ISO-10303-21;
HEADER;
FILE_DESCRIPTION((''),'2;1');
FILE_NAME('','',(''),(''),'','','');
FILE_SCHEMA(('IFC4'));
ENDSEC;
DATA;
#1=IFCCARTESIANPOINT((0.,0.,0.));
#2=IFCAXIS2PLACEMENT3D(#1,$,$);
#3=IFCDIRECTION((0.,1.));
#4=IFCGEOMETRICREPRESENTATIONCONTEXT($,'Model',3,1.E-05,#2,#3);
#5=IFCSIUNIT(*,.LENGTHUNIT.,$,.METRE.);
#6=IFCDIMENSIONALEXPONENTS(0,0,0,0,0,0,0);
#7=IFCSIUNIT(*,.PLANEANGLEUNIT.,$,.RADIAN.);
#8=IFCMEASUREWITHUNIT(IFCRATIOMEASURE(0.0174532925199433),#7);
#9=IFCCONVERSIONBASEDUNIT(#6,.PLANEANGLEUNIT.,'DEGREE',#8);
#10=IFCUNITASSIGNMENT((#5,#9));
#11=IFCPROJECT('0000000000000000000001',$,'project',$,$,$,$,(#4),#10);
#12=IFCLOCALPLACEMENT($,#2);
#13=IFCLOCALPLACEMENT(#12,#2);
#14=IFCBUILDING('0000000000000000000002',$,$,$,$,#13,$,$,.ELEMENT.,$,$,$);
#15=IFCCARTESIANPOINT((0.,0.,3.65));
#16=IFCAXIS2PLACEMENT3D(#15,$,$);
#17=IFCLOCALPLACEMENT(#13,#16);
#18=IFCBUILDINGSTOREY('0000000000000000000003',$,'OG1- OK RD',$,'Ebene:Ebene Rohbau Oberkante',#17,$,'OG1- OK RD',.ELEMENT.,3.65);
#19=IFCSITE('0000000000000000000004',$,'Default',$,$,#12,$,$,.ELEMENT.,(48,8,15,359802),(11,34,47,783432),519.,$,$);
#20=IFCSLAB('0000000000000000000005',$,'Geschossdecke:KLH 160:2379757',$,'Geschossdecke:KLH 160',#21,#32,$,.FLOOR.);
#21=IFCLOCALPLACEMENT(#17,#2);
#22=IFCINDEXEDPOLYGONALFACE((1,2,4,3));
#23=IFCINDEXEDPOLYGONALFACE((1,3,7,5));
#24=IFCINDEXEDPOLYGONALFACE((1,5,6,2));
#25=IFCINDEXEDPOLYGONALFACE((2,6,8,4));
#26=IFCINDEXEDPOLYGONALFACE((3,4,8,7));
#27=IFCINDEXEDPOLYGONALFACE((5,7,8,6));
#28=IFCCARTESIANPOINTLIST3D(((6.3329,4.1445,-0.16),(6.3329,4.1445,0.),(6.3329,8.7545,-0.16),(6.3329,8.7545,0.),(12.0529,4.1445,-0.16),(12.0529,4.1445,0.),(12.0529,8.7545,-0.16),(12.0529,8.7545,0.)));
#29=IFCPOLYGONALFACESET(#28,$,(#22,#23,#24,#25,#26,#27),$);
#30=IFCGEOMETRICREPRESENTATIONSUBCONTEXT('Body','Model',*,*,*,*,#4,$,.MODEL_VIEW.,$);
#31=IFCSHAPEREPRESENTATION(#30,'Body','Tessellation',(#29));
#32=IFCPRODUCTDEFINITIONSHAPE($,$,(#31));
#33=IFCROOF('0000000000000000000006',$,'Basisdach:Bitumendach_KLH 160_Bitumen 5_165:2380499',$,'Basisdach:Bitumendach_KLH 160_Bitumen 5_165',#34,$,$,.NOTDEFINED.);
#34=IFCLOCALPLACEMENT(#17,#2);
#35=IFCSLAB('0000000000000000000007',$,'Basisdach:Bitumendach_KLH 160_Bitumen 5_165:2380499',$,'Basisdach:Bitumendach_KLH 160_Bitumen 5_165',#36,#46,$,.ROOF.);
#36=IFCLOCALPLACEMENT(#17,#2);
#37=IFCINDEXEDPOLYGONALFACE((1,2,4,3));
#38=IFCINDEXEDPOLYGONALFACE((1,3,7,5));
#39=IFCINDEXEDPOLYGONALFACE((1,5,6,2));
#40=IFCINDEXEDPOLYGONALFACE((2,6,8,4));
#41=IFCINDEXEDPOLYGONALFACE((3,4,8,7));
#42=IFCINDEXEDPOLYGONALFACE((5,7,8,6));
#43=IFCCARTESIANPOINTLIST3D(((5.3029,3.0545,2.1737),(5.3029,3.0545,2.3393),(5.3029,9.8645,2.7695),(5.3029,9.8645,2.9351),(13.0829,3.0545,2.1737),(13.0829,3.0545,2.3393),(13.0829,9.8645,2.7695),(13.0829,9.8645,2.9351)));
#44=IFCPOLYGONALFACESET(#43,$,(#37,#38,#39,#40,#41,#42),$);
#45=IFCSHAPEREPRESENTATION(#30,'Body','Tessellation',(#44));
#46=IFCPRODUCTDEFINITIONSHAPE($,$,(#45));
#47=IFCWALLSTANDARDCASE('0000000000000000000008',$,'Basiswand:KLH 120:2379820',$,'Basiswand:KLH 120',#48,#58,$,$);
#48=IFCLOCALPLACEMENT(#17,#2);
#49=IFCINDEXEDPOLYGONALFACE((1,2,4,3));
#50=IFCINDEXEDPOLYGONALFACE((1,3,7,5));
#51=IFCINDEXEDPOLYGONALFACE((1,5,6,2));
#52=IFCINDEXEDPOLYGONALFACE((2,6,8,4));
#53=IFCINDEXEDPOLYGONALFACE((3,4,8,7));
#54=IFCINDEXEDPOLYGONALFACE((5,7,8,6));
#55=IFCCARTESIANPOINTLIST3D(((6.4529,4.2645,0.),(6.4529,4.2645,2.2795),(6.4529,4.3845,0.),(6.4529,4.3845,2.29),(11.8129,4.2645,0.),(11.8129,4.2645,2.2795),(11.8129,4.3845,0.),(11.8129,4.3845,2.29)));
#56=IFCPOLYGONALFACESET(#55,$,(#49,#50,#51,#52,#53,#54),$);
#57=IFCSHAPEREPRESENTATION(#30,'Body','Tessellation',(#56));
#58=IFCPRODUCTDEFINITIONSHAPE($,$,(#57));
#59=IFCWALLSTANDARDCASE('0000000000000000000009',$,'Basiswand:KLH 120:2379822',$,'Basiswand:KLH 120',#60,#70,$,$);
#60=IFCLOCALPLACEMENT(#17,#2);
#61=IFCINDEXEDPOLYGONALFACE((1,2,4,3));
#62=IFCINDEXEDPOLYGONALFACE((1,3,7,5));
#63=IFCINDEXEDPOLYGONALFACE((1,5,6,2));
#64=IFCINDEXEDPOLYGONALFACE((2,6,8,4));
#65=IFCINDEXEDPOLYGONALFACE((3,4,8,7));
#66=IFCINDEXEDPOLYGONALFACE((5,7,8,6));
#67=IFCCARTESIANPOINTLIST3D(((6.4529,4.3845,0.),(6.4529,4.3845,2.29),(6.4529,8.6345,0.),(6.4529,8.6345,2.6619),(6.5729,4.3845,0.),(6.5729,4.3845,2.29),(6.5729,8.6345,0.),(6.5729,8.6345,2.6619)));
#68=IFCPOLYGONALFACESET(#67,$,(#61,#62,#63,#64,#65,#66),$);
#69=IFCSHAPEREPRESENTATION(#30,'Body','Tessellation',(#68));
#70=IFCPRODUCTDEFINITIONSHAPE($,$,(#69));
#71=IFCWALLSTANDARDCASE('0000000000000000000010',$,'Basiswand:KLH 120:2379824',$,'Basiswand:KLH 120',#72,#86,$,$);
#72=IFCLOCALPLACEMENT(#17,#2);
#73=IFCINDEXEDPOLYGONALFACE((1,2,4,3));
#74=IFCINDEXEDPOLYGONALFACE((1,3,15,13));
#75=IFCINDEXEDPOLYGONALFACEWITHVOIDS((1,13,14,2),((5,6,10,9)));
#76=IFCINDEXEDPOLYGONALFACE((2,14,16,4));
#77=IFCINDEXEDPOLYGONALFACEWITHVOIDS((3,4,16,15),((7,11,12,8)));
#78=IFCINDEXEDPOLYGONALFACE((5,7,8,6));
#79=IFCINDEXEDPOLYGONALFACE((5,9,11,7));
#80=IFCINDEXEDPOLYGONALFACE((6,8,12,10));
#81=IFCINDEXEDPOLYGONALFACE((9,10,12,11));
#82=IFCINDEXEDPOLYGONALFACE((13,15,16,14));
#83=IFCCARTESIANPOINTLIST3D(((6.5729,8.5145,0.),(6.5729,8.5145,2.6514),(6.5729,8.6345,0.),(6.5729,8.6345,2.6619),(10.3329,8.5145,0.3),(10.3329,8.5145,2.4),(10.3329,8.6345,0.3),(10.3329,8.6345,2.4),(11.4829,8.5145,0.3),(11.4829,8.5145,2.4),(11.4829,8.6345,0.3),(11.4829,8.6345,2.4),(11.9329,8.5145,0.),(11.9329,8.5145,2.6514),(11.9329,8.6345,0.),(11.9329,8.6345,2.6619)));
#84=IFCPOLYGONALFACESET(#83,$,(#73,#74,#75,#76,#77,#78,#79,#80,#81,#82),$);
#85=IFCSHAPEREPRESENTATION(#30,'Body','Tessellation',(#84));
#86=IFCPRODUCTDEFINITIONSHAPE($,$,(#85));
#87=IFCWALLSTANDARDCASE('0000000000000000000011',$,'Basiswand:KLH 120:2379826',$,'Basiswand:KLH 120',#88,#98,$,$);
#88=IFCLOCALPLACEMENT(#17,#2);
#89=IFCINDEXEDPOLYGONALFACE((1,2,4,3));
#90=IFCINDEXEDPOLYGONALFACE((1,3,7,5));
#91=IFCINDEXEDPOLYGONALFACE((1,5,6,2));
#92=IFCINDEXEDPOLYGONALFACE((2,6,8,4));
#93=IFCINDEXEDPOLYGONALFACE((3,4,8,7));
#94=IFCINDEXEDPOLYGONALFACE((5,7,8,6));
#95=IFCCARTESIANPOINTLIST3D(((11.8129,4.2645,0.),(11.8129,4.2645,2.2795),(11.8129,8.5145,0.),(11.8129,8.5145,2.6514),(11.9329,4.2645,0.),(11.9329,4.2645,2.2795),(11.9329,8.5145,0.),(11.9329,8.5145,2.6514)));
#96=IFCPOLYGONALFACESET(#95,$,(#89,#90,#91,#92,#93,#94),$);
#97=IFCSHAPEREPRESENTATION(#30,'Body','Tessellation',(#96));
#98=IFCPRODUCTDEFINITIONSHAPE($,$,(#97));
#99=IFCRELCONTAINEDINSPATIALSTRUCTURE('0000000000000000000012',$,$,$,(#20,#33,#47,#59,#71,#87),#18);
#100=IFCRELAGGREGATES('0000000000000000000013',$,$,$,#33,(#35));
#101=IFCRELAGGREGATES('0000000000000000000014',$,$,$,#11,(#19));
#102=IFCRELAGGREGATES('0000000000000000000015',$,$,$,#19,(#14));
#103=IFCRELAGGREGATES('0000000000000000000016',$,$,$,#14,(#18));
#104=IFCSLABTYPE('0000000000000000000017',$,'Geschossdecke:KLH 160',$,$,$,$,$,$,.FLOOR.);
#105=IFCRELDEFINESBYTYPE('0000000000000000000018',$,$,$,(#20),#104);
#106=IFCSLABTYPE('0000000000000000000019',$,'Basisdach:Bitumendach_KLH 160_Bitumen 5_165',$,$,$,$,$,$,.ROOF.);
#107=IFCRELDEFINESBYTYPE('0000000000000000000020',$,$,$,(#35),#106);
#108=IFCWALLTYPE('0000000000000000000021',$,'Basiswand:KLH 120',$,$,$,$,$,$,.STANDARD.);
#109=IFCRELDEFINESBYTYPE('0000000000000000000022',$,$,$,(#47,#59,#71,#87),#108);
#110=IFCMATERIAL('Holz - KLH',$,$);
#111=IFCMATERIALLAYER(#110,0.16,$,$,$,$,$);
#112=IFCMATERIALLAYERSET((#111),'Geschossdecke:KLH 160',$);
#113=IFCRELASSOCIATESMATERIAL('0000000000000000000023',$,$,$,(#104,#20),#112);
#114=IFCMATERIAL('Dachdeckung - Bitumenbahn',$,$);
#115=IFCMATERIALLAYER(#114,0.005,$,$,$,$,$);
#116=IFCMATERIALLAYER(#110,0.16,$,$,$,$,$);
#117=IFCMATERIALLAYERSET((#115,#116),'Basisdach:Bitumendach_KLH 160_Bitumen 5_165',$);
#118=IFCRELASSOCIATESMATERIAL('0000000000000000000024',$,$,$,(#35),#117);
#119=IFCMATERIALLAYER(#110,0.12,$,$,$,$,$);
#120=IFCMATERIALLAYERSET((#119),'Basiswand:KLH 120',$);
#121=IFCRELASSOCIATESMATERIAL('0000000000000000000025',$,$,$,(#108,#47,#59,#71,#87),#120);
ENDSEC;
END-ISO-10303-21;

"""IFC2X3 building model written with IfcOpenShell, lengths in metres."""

from ifc_helpers import new_model, entity, si_unit, converted_unit, direction, frame, frame_2d, origin, place, context, subcontext, project, spatial, polyline, rectangle, extrude, clip, bounded_halfspace, material, layer, layer_set, layer_usage, type_object, element, aggregate, save


model = new_model("IFC2X3")

# Units and contexts
model_context = context("Model", 3, precision=1e-05, world=origin(), true_north=direction((0.0, 1.0)))
body_context = subcontext(model_context, "Body", "Model", "MODEL_VIEW")
ifc_project = project(units=[si_unit("LENGTHUNIT", "METRE"), converted_unit("PLANEANGLEUNIT", "DEGREE", entity("IfcRatioMeasure", 0.0174532925199433), si_unit("PLANEANGLEUNIT", "RADIAN"), dimensions=[0, 0, 0, 0, 0, 0, 0])], contexts=[model_context])

# Site, building, storey
site_placement = place(None, origin())
site = spatial("IfcSite", under=ifc_project, at=site_placement, Name="Default", CompositionType="ELEMENT", RefLatitude=(48, 8, 15, 359802), RefLongitude=(11, 34, 47, 783432), RefElevation=519.0)
building_placement = place(site_placement, origin())
building = spatial("IfcBuilding", under=site, at=building_placement, CompositionType="ELEMENT")
storey_placement = place(building_placement, frame((0.0, 0.0, 3.65)))
storey = spatial("IfcBuildingStorey", under=building, at=storey_placement, Name="OG1- OK RD", ObjectType="Ebene:Ebene Rohbau Oberkante", LongName="OG1- OK RD", CompositionType="ELEMENT", Elevation=3.65)

# Slab
ifc_material_1 = material(Name="Holz - KLH")
ifc_layer_1 = layer(ifc_material_1, 0.16)
ifc_layer_set_1 = layer_set([ifc_layer_1], Name="Geschossdecke:KLH 160")
ifc_layer_usage_1 = layer_usage(ifc_layer_set_1, "AXIS3", "POSITIVE", 0.0)
slab_type_1 = type_object("IfcSlabType", Name="Geschossdecke:KLH 160", PredefinedType="FLOOR", material=ifc_layer_set_1)
slab_1_placement = place(storey_placement, origin())
element("IfcSlab", 1, at=slab_1_placement, inside=storey, type_object=slab_type_1, material=ifc_layer_usage_1, Name="Geschossdecke:KLH 160:2379757", ObjectType="Geschossdecke:KLH 160", PredefinedType="FLOOR", context=body_context, shape_type="SweptSolid", body=[
    extrude(rectangle(XDim=4.61, YDim=5.72, at=frame_2d((0.0, 0.0), x_axis=(1.0, 0.0))), frame((9.1929, 6.4495, 0.0), z_axis=(0.0, 0.0, -1.0), x_axis=(0.0, 1.0, 0.0)), (0.0, 0.0, 1.0), 0.16),
])

# Roof, slab
roof_placement = place(storey_placement, frame((5.3029, 3.0545, 2.1737)))
roof = element("IfcRoof", 2, at=roof_placement, inside=storey, Name="Basisdach:Bitumendach_KLH 160_Bitumen 5_165:2380499", ObjectType="Basisdach:Bitumendach_KLH 160_Bitumen 5_165", ShapeType="NOTDEFINED")
ifc_material_2 = material(Name="Dachdeckung - Bitumenbahn")
ifc_layer_2 = layer(ifc_material_2, 0.005)
ifc_layer_3 = layer(ifc_material_1, 0.16)
ifc_layer_set_2 = layer_set([ifc_layer_2, ifc_layer_3], Name="Basisdach:Bitumendach_KLH 160_Bitumen 5_165")
slab_type_2 = type_object("IfcSlabType", Name="Basisdach:Bitumendach_KLH 160_Bitumen 5_165", PredefinedType="ROOF")
slab_2_placement = place(roof_placement, origin())
slab_2 = element("IfcSlab", 3, at=slab_2_placement, type_object=slab_type_2, material=ifc_layer_set_2, Name="Basisdach:Bitumendach_KLH 160_Bitumen 5_165:2380499", ObjectType="Basisdach:Bitumendach_KLH 160_Bitumen 5_165", PredefinedType="ROOF", context=body_context, shape_type="SweptSolid", body=[
    extrude(rectangle(XDim=6.836, YDim=7.78, at=frame_2d((0.0, 0.0), x_axis=(0.0, -1.0))), frame((3.89, 3.405, 0.2979), z_axis=(0.0, -0.087156, 0.996195), x_axis=(1.0, 0.0, 0.0)), (0.0, 0.087156, 0.996195), 0.1656),
])
aggregate(roof, [slab_2])

# Walls
ifc_layer_4 = layer(ifc_material_1, 0.12)
ifc_layer_set_3 = layer_set([ifc_layer_4], Name="Basiswand:KLH 120")
ifc_layer_usage_2 = layer_usage(ifc_layer_set_3, "AXIS2", "NEGATIVE", 0.06)
wall_type = type_object("IfcWallType", Name="Basiswand:KLH 120", PredefinedType="STANDARD", material=ifc_layer_set_3)
wall_1_placement = place(storey_placement, frame((6.4529, 4.3245, 0.0)))
element("IfcWallStandardCase", 4, at=wall_1_placement, inside=storey, type_object=wall_type, material=ifc_layer_usage_2, Name="Basiswand:KLH 120:2379820", ObjectType="Basiswand:KLH 120", context=body_context, shape_type="Clipping", body=[
    clip(extrude(rectangle(XDim=5.36, YDim=0.12, at=frame_2d((2.68, 0.0), x_axis=(-1.0, 0.0))), origin(), (0.0, 0.0, 1.0), 2.29), bounded_halfspace(frame((0.0, -0.06, 2.2795), z_axis=(0.0, -0.087156, 0.996195), x_axis=(1.0, 0.0, 0.0)), False, frame((0.0, -0.06, 2.2795)), polyline([(0.0, 0.0), (5.36, 0.0), (5.36, 0.12), (0.12, 0.12), (0.0, 0.12), (0.0, 0.0)]))),
])
ifc_layer_usage_3 = layer_usage(ifc_layer_set_3, "AXIS2", "NEGATIVE", 0.06)
wall_2_placement = place(storey_placement, frame((6.5129, 8.6345, 0.0), z_axis=(0.0, 0.0, 1.0), x_axis=(0.0, -1.0, 0.0)))
element("IfcWallStandardCase", 5, at=wall_2_placement, inside=storey, type_object=wall_type, material=ifc_layer_usage_3, Name="Basiswand:KLH 120:2379822", ObjectType="Basiswand:KLH 120", context=body_context, shape_type="Clipping", body=[
    clip(extrude(rectangle(XDim=4.25, YDim=0.12, at=frame_2d((2.125, 0.0), x_axis=(-1.0, 0.0))), origin(), (0.0, 0.0, 1.0), 2.6619), bounded_halfspace(frame((0.0, -0.06, 2.6619), z_axis=(0.087156, 0.0, 0.996195), x_axis=(0.0, 1.0, 0.0)), False, frame((0.0, -0.06, 2.6619)), polyline([(0.0, 0.0), (4.25, 0.0), (4.25, 0.12), (0.12, 0.12), (0.0, 0.12), (0.0, 0.0)]))),
])

# Wall, opening
ifc_layer_usage_4 = layer_usage(ifc_layer_set_3, "AXIS2", "NEGATIVE", 0.06)
wall_3_placement = place(storey_placement, frame((11.9329, 8.5745, 0.0), z_axis=(0.0, 0.0, 1.0), x_axis=(-1.0, 0.0, 0.0)))
wall_3 = element("IfcWallStandardCase", 6, at=wall_3_placement, inside=storey, type_object=wall_type, material=ifc_layer_usage_4, Name="Basiswand:KLH 120:2379824", ObjectType="Basiswand:KLH 120", context=body_context, shape_type="Clipping", body=[
    clip(extrude(rectangle(XDim=5.36, YDim=0.12, at=frame_2d((2.68, 0.0), x_axis=(-1.0, 0.0))), origin(), (0.0, 0.0, 1.0), 2.6619), bounded_halfspace(frame((0.0, -0.06, 2.6619), z_axis=(0.0, 0.087156, 0.996195), x_axis=(-1.0, 0.0, 0.0)), False, frame((0.0, -0.06, 2.6619)), polyline([(0.0, 0.0), (5.36, 0.0), (5.36, 0.12), (0.12, 0.12), (0.0, 0.12), (0.0, 0.0)]))),
])
opening_placement = place(wall_3_placement, frame((0.45, -0.06, 0.3)))
element("IfcOpeningElement", 7, at=opening_placement, cuts=wall_3, ObjectType="Opening", context=body_context, shape_type="SweptSolid", body=[
    extrude(rectangle(XDim=2.1, YDim=1.15, at=frame_2d((1.05, 0.575), x_axis=(-1.0, 0.0))), frame((0.0, 0.0, 0.0), z_axis=(0.0, 1.0, 0.0), x_axis=(0.0, 0.0, 1.0)), (0.0, 0.0, 1.0), 0.12),
])

# Wall
ifc_layer_usage_5 = layer_usage(ifc_layer_set_3, "AXIS2", "NEGATIVE", 0.06)
wall_4_placement = place(storey_placement, frame((11.8729, 4.2645, 0.0), z_axis=(0.0, 0.0, 1.0), x_axis=(0.0, 1.0, 0.0)))
element("IfcWallStandardCase", 8, at=wall_4_placement, inside=storey, type_object=wall_type, material=ifc_layer_usage_5, Name="Basiswand:KLH 120:2379826", ObjectType="Basiswand:KLH 120", context=body_context, shape_type="Clipping", body=[
    clip(extrude(rectangle(XDim=4.25, YDim=0.12, at=frame_2d((2.125, 0.0), x_axis=(-1.0, 0.0))), origin(), (0.0, 0.0, 1.0), 2.6514), bounded_halfspace(frame((0.0, -0.06, 2.2795), z_axis=(-0.087156, 0.0, 0.996195), x_axis=(0.0, -1.0, 0.0)), False, frame((0.0, -0.06, 2.2795)), polyline([(0.0, 0.0), (4.25, 0.0), (4.25, 0.12), (0.12, 0.12), (0.0, 0.12), (0.0, 0.0)]))),
])

save(model, "model.ifc")
